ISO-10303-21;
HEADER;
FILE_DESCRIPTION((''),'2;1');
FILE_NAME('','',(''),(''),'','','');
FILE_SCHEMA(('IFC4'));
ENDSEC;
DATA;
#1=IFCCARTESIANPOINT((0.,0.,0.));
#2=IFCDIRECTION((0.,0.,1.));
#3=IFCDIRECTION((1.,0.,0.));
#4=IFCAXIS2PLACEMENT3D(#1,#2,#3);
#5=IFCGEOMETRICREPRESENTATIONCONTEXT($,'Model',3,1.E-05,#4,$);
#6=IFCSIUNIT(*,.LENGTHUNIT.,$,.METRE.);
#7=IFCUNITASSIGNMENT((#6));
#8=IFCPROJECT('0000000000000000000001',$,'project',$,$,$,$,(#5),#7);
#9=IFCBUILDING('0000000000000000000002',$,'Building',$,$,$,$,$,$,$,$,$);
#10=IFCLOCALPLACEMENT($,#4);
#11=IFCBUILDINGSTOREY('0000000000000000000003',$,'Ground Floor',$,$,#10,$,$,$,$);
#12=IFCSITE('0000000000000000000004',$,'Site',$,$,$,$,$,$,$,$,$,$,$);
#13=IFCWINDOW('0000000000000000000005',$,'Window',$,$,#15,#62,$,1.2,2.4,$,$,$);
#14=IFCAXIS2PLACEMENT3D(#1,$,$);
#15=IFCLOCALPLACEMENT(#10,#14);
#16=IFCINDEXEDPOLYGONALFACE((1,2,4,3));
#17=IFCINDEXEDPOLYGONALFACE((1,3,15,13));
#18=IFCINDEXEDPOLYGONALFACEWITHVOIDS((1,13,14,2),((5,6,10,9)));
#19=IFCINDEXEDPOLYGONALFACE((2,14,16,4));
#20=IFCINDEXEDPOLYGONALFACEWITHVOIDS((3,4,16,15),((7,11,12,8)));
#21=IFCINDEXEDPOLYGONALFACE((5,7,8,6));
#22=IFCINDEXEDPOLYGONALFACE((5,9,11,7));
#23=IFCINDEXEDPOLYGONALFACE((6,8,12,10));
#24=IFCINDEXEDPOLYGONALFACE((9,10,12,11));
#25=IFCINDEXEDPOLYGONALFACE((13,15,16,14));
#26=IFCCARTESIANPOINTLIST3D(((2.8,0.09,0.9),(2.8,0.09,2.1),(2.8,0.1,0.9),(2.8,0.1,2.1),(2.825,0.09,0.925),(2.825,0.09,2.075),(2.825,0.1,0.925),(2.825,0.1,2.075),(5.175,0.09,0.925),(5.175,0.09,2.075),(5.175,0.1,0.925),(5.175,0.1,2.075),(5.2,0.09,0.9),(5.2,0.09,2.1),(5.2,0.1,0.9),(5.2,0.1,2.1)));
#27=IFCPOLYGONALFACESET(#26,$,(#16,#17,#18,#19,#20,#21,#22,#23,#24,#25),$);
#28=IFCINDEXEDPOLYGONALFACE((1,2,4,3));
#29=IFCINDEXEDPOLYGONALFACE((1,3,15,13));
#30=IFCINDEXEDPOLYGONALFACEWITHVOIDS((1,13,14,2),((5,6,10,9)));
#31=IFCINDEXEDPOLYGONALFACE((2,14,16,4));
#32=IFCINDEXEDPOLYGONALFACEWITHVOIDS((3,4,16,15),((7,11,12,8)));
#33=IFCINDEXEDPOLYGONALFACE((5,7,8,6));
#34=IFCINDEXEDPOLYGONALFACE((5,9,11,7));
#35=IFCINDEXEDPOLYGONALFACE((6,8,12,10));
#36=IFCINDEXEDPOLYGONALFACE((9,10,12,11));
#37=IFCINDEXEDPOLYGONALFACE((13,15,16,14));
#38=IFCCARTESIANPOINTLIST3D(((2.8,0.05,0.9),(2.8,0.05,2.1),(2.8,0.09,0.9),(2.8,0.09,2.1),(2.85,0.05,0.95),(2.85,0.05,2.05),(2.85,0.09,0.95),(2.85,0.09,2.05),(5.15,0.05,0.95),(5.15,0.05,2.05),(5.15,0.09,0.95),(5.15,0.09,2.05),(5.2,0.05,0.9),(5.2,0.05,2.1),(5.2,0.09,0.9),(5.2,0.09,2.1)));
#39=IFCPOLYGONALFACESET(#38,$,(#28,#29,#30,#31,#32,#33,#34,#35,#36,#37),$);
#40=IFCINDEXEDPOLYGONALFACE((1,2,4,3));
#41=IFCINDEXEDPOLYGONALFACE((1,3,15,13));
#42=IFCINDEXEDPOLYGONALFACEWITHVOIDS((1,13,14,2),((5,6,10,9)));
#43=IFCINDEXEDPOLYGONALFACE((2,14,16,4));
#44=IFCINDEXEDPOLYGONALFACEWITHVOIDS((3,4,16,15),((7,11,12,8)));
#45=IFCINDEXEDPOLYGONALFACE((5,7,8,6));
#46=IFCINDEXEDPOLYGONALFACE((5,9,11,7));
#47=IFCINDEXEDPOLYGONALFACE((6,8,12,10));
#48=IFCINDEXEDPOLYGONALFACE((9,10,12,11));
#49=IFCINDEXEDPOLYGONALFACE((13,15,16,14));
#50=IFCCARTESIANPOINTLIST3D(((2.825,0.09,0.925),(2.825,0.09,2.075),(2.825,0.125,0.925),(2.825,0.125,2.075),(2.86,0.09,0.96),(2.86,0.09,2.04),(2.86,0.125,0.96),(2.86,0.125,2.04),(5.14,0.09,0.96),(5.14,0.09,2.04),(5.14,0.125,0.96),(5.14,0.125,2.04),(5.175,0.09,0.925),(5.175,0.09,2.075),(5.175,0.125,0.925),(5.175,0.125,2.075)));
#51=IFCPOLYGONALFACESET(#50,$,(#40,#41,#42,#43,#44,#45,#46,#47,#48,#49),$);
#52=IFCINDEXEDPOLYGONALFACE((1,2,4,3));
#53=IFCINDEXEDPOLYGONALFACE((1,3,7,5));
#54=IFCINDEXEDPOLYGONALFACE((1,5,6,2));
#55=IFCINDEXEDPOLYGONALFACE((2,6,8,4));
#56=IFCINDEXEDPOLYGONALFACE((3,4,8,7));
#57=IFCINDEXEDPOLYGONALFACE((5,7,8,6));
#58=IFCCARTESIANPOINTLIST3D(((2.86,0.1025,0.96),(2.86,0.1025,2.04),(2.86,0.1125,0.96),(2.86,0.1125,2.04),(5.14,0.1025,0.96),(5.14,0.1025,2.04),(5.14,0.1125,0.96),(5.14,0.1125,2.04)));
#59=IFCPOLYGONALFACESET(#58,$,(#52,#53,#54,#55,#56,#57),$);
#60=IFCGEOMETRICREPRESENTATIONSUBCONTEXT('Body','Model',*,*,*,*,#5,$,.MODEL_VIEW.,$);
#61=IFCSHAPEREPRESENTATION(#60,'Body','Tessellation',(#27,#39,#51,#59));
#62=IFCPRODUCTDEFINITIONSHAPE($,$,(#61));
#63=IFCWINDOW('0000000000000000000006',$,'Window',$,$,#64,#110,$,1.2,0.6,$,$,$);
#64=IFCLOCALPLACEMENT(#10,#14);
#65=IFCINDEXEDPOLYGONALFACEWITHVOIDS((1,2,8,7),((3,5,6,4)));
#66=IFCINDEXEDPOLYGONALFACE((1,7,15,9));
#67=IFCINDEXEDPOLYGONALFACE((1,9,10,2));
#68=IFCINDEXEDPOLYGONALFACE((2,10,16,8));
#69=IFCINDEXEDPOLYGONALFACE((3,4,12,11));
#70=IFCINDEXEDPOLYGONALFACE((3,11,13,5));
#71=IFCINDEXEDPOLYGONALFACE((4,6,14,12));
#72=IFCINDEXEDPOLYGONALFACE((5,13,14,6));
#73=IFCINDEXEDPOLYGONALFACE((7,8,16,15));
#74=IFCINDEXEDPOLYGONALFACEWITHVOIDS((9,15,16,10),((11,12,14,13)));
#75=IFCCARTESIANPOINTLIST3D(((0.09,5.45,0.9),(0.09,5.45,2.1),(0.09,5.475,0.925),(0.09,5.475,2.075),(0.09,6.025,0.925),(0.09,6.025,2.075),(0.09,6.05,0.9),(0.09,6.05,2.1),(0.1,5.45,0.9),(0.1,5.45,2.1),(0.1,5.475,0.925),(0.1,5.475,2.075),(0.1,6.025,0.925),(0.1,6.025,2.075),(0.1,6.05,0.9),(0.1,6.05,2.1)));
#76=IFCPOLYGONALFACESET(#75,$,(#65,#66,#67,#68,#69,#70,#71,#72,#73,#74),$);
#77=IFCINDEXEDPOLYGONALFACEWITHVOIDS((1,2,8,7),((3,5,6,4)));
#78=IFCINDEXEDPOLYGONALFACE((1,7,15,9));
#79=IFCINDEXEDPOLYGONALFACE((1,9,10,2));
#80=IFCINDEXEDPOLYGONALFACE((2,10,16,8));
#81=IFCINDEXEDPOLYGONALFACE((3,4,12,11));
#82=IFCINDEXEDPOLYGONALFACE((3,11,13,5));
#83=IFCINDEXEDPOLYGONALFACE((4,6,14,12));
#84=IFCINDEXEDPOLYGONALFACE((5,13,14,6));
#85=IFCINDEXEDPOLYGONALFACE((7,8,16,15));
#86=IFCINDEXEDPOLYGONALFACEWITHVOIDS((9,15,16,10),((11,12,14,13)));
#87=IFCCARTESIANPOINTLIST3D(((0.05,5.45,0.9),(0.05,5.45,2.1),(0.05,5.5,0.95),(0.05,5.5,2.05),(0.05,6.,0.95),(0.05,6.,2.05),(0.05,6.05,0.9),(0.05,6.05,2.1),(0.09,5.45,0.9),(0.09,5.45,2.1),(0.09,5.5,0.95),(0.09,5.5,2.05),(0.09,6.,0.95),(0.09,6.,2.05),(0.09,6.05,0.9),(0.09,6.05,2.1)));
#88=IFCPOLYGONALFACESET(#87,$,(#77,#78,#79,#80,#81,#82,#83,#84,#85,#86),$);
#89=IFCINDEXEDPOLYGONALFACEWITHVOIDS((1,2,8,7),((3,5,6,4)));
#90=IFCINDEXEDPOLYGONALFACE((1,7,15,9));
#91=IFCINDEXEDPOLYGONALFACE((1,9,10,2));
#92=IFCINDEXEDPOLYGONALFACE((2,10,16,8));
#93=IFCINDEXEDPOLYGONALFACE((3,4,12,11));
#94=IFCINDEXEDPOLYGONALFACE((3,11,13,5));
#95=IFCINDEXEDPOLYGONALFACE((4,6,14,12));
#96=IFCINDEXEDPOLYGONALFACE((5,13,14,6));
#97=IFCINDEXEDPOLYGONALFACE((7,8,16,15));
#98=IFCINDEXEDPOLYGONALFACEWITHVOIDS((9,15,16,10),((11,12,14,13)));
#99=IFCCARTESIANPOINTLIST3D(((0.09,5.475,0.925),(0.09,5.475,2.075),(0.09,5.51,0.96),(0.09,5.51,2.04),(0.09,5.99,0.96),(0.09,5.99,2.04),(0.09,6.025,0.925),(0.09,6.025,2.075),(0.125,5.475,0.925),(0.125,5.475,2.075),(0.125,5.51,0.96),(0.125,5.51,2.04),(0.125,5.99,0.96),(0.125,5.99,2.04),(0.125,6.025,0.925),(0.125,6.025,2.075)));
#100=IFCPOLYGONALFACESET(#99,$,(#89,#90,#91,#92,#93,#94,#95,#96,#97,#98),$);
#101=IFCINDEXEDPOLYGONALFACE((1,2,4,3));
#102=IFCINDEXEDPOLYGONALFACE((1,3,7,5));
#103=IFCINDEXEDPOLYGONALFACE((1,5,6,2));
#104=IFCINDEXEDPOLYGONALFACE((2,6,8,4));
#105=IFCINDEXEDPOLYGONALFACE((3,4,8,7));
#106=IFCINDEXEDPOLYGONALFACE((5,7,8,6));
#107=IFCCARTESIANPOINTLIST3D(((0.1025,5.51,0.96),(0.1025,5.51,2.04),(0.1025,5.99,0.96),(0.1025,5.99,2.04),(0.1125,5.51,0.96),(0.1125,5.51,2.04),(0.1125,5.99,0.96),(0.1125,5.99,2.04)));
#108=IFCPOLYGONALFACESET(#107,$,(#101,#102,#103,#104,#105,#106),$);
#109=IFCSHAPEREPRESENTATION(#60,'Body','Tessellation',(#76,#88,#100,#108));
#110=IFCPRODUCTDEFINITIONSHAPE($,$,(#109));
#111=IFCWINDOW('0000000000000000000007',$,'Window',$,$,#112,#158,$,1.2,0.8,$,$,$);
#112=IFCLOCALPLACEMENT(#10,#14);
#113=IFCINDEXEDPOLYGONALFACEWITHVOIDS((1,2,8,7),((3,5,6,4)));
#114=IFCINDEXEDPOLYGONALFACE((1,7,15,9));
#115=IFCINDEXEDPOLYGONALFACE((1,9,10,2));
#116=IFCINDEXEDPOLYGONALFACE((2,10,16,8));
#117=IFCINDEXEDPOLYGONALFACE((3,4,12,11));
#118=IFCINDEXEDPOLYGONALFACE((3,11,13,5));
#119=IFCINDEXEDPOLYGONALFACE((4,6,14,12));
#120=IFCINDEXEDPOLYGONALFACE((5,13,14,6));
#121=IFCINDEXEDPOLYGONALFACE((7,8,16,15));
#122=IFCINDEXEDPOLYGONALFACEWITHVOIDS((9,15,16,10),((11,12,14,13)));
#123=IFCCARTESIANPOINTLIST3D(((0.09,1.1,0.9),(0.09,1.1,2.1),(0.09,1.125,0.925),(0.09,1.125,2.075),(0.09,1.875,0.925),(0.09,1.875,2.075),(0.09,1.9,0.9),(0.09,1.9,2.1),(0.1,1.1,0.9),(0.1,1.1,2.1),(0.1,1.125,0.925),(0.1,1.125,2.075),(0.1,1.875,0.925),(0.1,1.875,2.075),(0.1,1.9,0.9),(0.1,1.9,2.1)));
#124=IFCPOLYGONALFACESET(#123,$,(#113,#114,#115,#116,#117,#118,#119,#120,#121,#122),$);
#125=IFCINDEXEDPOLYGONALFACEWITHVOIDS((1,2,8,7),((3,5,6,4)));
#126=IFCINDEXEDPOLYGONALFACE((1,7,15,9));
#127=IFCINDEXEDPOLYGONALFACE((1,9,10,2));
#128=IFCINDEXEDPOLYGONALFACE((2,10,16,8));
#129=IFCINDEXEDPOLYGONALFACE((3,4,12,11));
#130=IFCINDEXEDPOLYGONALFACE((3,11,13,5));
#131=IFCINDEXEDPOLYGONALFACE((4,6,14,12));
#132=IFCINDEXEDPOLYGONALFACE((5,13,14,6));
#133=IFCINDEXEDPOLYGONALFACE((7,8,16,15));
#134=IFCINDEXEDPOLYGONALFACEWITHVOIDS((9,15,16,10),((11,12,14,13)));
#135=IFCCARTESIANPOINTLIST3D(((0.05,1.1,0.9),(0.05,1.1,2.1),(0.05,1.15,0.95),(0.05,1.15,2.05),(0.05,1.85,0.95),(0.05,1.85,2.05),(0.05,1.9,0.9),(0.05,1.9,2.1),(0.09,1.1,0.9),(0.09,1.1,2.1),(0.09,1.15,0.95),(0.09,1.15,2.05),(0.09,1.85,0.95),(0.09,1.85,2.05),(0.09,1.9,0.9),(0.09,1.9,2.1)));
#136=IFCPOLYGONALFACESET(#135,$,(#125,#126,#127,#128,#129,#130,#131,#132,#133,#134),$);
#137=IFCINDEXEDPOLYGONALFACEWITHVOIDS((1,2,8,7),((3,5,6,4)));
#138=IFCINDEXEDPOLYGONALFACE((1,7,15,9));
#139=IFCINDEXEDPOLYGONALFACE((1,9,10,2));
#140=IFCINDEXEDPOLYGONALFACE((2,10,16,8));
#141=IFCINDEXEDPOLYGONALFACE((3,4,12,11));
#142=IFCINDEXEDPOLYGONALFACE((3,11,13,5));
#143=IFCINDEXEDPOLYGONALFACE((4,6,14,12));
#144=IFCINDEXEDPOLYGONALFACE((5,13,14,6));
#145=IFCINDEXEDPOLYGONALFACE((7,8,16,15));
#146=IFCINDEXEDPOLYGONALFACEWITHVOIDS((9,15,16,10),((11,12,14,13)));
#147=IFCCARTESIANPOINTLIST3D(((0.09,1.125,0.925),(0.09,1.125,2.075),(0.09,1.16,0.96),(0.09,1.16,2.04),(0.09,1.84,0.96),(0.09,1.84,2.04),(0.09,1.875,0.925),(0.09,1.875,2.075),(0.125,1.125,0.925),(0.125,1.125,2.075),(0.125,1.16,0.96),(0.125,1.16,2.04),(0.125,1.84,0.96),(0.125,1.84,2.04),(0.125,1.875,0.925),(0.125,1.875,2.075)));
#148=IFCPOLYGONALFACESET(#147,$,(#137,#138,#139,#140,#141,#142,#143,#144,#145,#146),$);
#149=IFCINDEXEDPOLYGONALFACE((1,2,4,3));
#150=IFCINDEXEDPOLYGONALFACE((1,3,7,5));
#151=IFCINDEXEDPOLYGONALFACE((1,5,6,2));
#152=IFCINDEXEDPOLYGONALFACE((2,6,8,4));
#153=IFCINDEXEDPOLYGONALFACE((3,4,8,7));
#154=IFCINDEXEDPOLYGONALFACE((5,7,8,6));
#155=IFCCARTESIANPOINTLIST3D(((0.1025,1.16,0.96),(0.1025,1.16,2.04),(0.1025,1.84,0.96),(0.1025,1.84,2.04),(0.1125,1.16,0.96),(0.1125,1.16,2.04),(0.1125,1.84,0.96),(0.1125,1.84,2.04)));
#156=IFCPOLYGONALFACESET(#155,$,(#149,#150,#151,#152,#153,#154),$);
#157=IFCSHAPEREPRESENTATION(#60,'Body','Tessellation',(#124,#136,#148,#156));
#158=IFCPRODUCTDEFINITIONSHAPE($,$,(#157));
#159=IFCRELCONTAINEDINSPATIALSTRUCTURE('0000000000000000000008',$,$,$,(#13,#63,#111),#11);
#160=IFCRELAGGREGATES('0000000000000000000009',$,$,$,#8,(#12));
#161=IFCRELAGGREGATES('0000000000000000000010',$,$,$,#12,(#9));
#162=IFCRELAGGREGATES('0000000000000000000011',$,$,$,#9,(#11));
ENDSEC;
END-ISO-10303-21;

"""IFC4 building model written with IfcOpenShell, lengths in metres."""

from ifc_helpers import new_model, si_unit, frame, origin_with_axes, place, context, subcontext, project, spatial, line, indexed_curve, outline, extrude, element, save


model = new_model("IFC4")

# Units and contexts
model_context = context("Model", 3, precision=1e-05, world=origin_with_axes())
body_context = subcontext(model_context, "Body", "Model", "MODEL_VIEW")
ifc_project = project(units=[si_unit("LENGTHUNIT", "METRE")], contexts=[model_context])

# Site, building, storey
site = spatial("IfcSite", under=ifc_project, Name="Site")
building = spatial("IfcBuilding", under=site, Name="Building")
storey_placement = place(None, origin_with_axes())
storey = spatial("IfcBuildingStorey", under=building, at=storey_placement, Name="Ground Floor")

# Windows
window_1_placement = place(storey_placement, frame((2.8, 0.0, 0.9), z_axis=(0.0, 0.0, 1.0), x_axis=(1.0, 0.0, 0.0)))
element("IfcWindow", 1, at=window_1_placement, inside=storey, Name="Window", OverallHeight=1.2, OverallWidth=2.4, context=body_context, shape_type="SweptSolid", body=[
    extrude(outline(indexed_curve([(0.0, 0.0), (2.4, 0.0), (2.4, 1.2), (0.0, 1.2)], segments=[line(1, 2, 3, 4, 1)]), holes=[indexed_curve([(0.025, 0.025), (2.375, 0.025), (2.375, 1.175), (0.025, 1.175)], segments=[line(1, 2, 3, 4, 1)])]), frame((0.0, 0.09, 0.0), z_axis=(0.0, -1.0, 0.0), x_axis=(1.0, 0.0, 0.0)), (0.0, 0.0, -1.0), 0.01),
    extrude(outline(indexed_curve([(0.0, 0.0), (2.4, 0.0), (2.4, 1.2), (0.0, 1.2)], segments=[line(1, 2, 3, 4, 1)]), holes=[indexed_curve([(0.05, 0.05), (2.35, 0.05), (2.35, 1.15), (0.05, 1.15)], segments=[line(1, 2, 3, 4, 1)])]), frame((0.0, 0.05, 0.0), z_axis=(0.0, -1.0, 0.0), x_axis=(1.0, 0.0, 0.0)), (0.0, 0.0, -1.0), 0.04),
    extrude(outline(indexed_curve([(0.0, 0.0), (2.35, 0.0), (2.35, 1.15), (0.0, 1.15)], segments=[line(1, 2, 3, 4, 1)]), holes=[indexed_curve([(0.035, 0.035), (2.315, 0.035), (2.315, 1.115), (0.035, 1.115)], segments=[line(1, 2, 3, 4, 1)])]), frame((0.025, 0.09, 0.025), z_axis=(0.0, -1.0, 0.0), x_axis=(1.0, 0.0, 0.0)), (0.0, 0.0, -1.0), 0.035),
    extrude(outline(indexed_curve([(0.035, 0.035), (2.315, 0.035), (2.315, 1.115), (0.035, 1.115)], segments=[line(1, 2, 3, 4, 1)])), frame((0.025, 0.1025, 0.025), z_axis=(0.0, -1.0, 0.0), x_axis=(1.0, 0.0, 0.0)), (0.0, 0.0, -1.0), 0.01),
])
window_2_placement = place(storey_placement, frame((0.0, 6.05, 0.9), z_axis=(0.0, 0.0, 1.0), x_axis=(0.0, -1.0, 0.0)))
element("IfcWindow", 2, at=window_2_placement, inside=storey, Name="Window", OverallHeight=1.2, OverallWidth=0.6, context=body_context, shape_type="SweptSolid", body=[
    extrude(outline(indexed_curve([(0.0, 0.0), (0.6, 0.0), (0.6, 1.2), (0.0, 1.2)], segments=[line(1, 2, 3, 4, 1)]), holes=[indexed_curve([(0.025, 0.025), (0.575, 0.025), (0.575, 1.175), (0.025, 1.175)], segments=[line(1, 2, 3, 4, 1)])]), frame((0.0, 0.09, 0.0), z_axis=(0.0, -1.0, 0.0), x_axis=(1.0, 0.0, 0.0)), (0.0, 0.0, -1.0), 0.01),
    extrude(outline(indexed_curve([(0.0, 0.0), (0.6, 0.0), (0.6, 1.2), (0.0, 1.2)], segments=[line(1, 2, 3, 4, 1)]), holes=[indexed_curve([(0.05, 0.05), (0.55, 0.05), (0.55, 1.15), (0.05, 1.15)], segments=[line(1, 2, 3, 4, 1)])]), frame((0.0, 0.05, 0.0), z_axis=(0.0, -1.0, 0.0), x_axis=(1.0, 0.0, 0.0)), (0.0, 0.0, -1.0), 0.04),
    extrude(outline(indexed_curve([(0.0, 0.0), (0.55, 0.0), (0.55, 1.15), (0.0, 1.15)], segments=[line(1, 2, 3, 4, 1)]), holes=[indexed_curve([(0.035, 0.035), (0.515, 0.035), (0.515, 1.115), (0.035, 1.115)], segments=[line(1, 2, 3, 4, 1)])]), frame((0.025, 0.09, 0.025), z_axis=(0.0, -1.0, 0.0), x_axis=(1.0, 0.0, 0.0)), (0.0, 0.0, -1.0), 0.035),
    extrude(outline(indexed_curve([(0.035, 0.035), (0.515, 0.035), (0.515, 1.115), (0.035, 1.115)], segments=[line(1, 2, 3, 4, 1)])), frame((0.025, 0.1025, 0.025), z_axis=(0.0, -1.0, 0.0), x_axis=(1.0, 0.0, 0.0)), (0.0, 0.0, -1.0), 0.01),
])
window_3_placement = place(storey_placement, frame((0.0, 1.9, 0.9), z_axis=(0.0, 0.0, 1.0), x_axis=(0.0, -1.0, 0.0)))
element("IfcWindow", 3, at=window_3_placement, inside=storey, Name="Window", OverallHeight=1.2, OverallWidth=0.8, context=body_context, shape_type="SweptSolid", body=[
    extrude(outline(indexed_curve([(0.0, 0.0), (0.8, 0.0), (0.8, 1.2), (0.0, 1.2)], segments=[line(1, 2, 3, 4, 1)]), holes=[indexed_curve([(0.025, 0.025), (0.775, 0.025), (0.775, 1.175), (0.025, 1.175)], segments=[line(1, 2, 3, 4, 1)])]), frame((0.0, 0.09, 0.0), z_axis=(0.0, -1.0, 0.0), x_axis=(1.0, 0.0, 0.0)), (0.0, 0.0, -1.0), 0.01),
    extrude(outline(indexed_curve([(0.0, 0.0), (0.8, 0.0), (0.8, 1.2), (0.0, 1.2)], segments=[line(1, 2, 3, 4, 1)]), holes=[indexed_curve([(0.05, 0.05), (0.75, 0.05), (0.75, 1.15), (0.05, 1.15)], segments=[line(1, 2, 3, 4, 1)])]), frame((0.0, 0.05, 0.0), z_axis=(0.0, -1.0, 0.0), x_axis=(1.0, 0.0, 0.0)), (0.0, 0.0, -1.0), 0.04),
    extrude(outline(indexed_curve([(0.0, 0.0), (0.75, 0.0), (0.75, 1.15), (0.0, 1.15)], segments=[line(1, 2, 3, 4, 1)]), holes=[indexed_curve([(0.035, 0.035), (0.715, 0.035), (0.715, 1.115), (0.035, 1.115)], segments=[line(1, 2, 3, 4, 1)])]), frame((0.025, 0.09, 0.025), z_axis=(0.0, -1.0, 0.0), x_axis=(1.0, 0.0, 0.0)), (0.0, 0.0, -1.0), 0.035),
    extrude(outline(indexed_curve([(0.035, 0.035), (0.715, 0.035), (0.715, 1.115), (0.035, 1.115)], segments=[line(1, 2, 3, 4, 1)])), frame((0.025, 0.1025, 0.025), z_axis=(0.0, -1.0, 0.0), x_axis=(1.0, 0.0, 0.0)), (0.0, 0.0, -1.0), 0.01),
])

save(model, "model.ifc")
